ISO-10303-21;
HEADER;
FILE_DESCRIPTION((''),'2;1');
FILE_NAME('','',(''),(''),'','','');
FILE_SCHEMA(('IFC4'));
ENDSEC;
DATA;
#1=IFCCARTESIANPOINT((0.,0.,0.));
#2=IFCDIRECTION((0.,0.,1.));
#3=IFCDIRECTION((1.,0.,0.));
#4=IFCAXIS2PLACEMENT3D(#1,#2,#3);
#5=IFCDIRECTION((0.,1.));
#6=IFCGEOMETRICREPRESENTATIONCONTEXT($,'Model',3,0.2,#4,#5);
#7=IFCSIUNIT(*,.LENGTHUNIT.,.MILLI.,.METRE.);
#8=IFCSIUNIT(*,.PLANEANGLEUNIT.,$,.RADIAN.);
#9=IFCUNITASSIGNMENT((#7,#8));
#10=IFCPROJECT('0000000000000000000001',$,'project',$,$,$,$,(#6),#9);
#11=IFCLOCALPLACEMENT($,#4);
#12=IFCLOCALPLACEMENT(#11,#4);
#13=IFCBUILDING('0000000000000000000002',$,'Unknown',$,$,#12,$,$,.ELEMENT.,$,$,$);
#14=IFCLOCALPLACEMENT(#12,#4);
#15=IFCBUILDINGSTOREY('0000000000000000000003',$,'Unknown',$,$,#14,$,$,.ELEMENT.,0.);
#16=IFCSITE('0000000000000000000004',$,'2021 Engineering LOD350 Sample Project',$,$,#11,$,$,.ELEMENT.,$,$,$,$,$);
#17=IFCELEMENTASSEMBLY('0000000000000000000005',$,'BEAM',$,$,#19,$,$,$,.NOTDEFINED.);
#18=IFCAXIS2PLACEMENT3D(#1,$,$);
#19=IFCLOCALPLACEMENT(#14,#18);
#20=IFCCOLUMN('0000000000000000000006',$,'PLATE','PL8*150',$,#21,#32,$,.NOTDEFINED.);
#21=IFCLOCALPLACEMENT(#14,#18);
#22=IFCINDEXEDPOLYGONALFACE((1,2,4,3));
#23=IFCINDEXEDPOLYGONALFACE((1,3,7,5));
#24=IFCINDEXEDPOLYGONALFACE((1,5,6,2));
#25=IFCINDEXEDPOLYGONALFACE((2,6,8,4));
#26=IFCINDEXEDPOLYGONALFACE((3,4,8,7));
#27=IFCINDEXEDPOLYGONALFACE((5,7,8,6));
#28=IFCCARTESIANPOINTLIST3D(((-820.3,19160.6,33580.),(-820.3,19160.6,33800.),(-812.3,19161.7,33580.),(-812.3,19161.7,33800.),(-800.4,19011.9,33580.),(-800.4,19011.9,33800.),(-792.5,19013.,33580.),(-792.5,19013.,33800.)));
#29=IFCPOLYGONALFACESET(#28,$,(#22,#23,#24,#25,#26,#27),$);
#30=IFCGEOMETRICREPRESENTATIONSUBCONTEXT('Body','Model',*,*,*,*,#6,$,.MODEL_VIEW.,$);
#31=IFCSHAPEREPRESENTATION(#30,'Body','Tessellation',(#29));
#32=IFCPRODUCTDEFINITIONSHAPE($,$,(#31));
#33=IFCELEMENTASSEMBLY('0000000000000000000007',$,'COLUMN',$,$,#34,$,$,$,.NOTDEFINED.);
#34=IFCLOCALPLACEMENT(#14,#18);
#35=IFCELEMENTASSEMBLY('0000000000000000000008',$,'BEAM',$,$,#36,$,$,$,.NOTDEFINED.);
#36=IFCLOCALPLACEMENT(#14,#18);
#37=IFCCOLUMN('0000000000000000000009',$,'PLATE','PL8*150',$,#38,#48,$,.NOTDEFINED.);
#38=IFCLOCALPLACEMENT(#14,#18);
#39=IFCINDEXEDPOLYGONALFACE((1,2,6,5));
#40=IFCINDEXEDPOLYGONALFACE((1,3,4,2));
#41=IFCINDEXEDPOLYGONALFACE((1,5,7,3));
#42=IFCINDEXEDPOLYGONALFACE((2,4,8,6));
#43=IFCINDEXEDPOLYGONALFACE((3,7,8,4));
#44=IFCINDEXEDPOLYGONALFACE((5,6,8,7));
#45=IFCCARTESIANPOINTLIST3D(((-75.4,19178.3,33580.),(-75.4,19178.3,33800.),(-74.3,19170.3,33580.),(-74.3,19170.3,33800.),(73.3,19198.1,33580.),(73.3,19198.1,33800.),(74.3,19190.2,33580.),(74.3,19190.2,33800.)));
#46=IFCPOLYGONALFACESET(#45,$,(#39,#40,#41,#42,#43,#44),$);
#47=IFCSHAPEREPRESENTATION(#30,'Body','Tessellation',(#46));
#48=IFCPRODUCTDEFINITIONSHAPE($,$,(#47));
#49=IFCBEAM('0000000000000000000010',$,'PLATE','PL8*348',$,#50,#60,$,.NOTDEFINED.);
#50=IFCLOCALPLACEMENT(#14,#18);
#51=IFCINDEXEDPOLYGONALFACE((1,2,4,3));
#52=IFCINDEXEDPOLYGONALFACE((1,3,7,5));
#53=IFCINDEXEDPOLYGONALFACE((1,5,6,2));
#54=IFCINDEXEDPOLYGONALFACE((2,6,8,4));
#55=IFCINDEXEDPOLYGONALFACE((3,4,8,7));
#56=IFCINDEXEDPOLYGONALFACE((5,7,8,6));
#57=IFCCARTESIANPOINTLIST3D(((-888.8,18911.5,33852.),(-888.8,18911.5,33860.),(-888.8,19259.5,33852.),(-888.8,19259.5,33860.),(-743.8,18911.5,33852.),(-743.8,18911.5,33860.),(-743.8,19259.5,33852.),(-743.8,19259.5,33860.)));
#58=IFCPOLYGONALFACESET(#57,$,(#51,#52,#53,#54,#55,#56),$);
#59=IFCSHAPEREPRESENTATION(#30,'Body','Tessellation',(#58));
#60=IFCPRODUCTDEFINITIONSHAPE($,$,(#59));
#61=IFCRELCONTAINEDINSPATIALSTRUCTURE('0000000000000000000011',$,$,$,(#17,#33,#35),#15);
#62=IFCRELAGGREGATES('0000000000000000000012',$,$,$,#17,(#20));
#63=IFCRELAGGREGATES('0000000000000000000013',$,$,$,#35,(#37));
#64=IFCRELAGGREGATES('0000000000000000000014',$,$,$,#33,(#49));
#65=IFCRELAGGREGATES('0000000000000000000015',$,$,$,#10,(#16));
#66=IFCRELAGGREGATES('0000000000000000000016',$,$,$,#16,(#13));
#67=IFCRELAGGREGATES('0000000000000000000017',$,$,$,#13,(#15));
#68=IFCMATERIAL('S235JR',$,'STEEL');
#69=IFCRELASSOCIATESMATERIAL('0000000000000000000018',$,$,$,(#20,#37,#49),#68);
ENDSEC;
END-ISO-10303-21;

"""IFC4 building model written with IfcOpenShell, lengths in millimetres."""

from ifc_helpers import new_model, si_unit, direction, frame, origin_with_axes, place, context, subcontext, project, spatial, line, indexed_curve, outline, extrude, material, element, aggregate, save


model = new_model("IFC4")

# Units and contexts
model_context = context("Model", 3, precision=0.2, world=origin_with_axes(), true_north=direction((0.0, 1.0)))
body_context = subcontext(model_context, "Body", "Model", "MODEL_VIEW")
ifc_project = project(units=[si_unit("LENGTHUNIT", "METRE", prefix="MILLI"), si_unit("PLANEANGLEUNIT", "RADIAN")], contexts=[model_context])

# Site, building, storey
site_placement = place(None, origin_with_axes())
site = spatial("IfcSite", under=ifc_project, at=site_placement, Name="2021 Engineering LOD350 Sample Project", CompositionType="ELEMENT")
building_placement = place(site_placement, origin_with_axes())
building = spatial("IfcBuilding", under=site, at=building_placement, Name="Unknown", CompositionType="ELEMENT")
storey_placement = place(building_placement, origin_with_axes())
storey = spatial("IfcBuildingStorey", under=building, at=storey_placement, Name="Unknown", CompositionType="ELEMENT", Elevation=0.0)

# Element assembly, column
assembly_1_placement = place(storey_placement, frame((-816.3, 19085.5, 33670.0), z_axis=(0.132256, -0.991216, 0.0), x_axis=(0.991216, 0.132256, 0.0)))
assembly_1 = element("IfcElementAssembly", 1, at=assembly_1_placement, inside=storey, Name="BEAM", PredefinedType="NOTDEFINED")
ifc_material_1 = material(Name="S235JR", Category="STEEL")
column_1_placement = place(assembly_1_placement, frame((10.0, -90.0, 0.0), z_axis=(1.0, 0.0, -0.000004), x_axis=(0.0, 1.0, 0.0)))
column_1 = element("IfcColumn", 2, at=column_1_placement, material=ifc_material_1, Name="PLATE", Description="PL8*150", PredefinedType="NOTDEFINED", context=body_context, shape_type="SolidModel", body=[
    extrude(outline(indexed_curve([(-4.0, -75.0), (4.0, -75.0), (4.0, 75.0), (-4.0, 75.0)], segments=[line(1, 2, 3, 4, 1)])), frame((0.0, 0.0, 0.0), z_axis=(-1.0, 0.0, 0.0), x_axis=(0.0, 0.0, 1.0)), (0.0, 0.0, -1.0), 220.0),
])

# Element assembly
assembly_2_placement = place(storey_placement, frame((-816.3, 19085.5, 33850.0), z_axis=(0.0, -1.0, 0.0), x_axis=(0.0, 0.0, 1.0)))
assembly_2 = element("IfcElementAssembly", 3, at=assembly_2_placement, inside=storey, Name="COLUMN", PredefinedType="NOTDEFINED")

# Element assembly, column
assembly_3_placement = place(storey_placement, frame((0.0, 18600.0, 33670.0), z_axis=(1.0, 0.0, 0.0), x_axis=(0.0, 1.0, 0.0)))
assembly_3 = element("IfcElementAssembly", 4, at=assembly_3_placement, inside=storey, Name="BEAM", PredefinedType="NOTDEFINED")
column_2_placement = place(assembly_3_placement, frame((584.2, -90.0, -0.5), z_axis=(-0.991216, 0.0, 0.132256), x_axis=(0.0, 1.0, 0.0)))
column_2 = element("IfcColumn", 5, at=column_2_placement, material=ifc_material_1, Name="PLATE", Description="PL8*150", PredefinedType="NOTDEFINED", context=body_context, shape_type="SolidModel", body=[
    extrude(outline(indexed_curve([(-4.0, -75.0), (4.0, -75.0), (4.0, 75.0), (-4.0, 75.0)], segments=[line(1, 2, 3, 4, 1)])), frame((0.0, 0.0, 0.0), z_axis=(-1.0, 0.0, 0.0), x_axis=(0.0, 0.0, 1.0)), (0.0, 0.0, -1.0), 220.0),
])

# Beam
beam_placement = place(assembly_2_placement, frame((6.0, -72.5, 0.0), z_axis=(1.0, 0.0, 0.0), x_axis=(0.0, 1.0, 0.0)))
beam = element("IfcBeam", 6, at=beam_placement, material=ifc_material_1, Name="PLATE", Description="PL8*348", PredefinedType="NOTDEFINED", context=body_context, shape_type="SolidModel", body=[
    extrude(outline(indexed_curve([(-4.0, -174.0), (4.0, -174.0), (4.0, 174.0), (-4.0, 174.0)], segments=[line(1, 2, 3, 4, 1)])), frame((0.0, 0.0, 0.0), z_axis=(-1.0, 0.0, 0.0), x_axis=(0.0, 0.0, 1.0)), (0.0, 0.0, -1.0), 145.0),
])

aggregate(assembly_1, [column_1])
aggregate(assembly_3, [column_2])
aggregate(assembly_2, [beam])

save(model, "model.ifc")
